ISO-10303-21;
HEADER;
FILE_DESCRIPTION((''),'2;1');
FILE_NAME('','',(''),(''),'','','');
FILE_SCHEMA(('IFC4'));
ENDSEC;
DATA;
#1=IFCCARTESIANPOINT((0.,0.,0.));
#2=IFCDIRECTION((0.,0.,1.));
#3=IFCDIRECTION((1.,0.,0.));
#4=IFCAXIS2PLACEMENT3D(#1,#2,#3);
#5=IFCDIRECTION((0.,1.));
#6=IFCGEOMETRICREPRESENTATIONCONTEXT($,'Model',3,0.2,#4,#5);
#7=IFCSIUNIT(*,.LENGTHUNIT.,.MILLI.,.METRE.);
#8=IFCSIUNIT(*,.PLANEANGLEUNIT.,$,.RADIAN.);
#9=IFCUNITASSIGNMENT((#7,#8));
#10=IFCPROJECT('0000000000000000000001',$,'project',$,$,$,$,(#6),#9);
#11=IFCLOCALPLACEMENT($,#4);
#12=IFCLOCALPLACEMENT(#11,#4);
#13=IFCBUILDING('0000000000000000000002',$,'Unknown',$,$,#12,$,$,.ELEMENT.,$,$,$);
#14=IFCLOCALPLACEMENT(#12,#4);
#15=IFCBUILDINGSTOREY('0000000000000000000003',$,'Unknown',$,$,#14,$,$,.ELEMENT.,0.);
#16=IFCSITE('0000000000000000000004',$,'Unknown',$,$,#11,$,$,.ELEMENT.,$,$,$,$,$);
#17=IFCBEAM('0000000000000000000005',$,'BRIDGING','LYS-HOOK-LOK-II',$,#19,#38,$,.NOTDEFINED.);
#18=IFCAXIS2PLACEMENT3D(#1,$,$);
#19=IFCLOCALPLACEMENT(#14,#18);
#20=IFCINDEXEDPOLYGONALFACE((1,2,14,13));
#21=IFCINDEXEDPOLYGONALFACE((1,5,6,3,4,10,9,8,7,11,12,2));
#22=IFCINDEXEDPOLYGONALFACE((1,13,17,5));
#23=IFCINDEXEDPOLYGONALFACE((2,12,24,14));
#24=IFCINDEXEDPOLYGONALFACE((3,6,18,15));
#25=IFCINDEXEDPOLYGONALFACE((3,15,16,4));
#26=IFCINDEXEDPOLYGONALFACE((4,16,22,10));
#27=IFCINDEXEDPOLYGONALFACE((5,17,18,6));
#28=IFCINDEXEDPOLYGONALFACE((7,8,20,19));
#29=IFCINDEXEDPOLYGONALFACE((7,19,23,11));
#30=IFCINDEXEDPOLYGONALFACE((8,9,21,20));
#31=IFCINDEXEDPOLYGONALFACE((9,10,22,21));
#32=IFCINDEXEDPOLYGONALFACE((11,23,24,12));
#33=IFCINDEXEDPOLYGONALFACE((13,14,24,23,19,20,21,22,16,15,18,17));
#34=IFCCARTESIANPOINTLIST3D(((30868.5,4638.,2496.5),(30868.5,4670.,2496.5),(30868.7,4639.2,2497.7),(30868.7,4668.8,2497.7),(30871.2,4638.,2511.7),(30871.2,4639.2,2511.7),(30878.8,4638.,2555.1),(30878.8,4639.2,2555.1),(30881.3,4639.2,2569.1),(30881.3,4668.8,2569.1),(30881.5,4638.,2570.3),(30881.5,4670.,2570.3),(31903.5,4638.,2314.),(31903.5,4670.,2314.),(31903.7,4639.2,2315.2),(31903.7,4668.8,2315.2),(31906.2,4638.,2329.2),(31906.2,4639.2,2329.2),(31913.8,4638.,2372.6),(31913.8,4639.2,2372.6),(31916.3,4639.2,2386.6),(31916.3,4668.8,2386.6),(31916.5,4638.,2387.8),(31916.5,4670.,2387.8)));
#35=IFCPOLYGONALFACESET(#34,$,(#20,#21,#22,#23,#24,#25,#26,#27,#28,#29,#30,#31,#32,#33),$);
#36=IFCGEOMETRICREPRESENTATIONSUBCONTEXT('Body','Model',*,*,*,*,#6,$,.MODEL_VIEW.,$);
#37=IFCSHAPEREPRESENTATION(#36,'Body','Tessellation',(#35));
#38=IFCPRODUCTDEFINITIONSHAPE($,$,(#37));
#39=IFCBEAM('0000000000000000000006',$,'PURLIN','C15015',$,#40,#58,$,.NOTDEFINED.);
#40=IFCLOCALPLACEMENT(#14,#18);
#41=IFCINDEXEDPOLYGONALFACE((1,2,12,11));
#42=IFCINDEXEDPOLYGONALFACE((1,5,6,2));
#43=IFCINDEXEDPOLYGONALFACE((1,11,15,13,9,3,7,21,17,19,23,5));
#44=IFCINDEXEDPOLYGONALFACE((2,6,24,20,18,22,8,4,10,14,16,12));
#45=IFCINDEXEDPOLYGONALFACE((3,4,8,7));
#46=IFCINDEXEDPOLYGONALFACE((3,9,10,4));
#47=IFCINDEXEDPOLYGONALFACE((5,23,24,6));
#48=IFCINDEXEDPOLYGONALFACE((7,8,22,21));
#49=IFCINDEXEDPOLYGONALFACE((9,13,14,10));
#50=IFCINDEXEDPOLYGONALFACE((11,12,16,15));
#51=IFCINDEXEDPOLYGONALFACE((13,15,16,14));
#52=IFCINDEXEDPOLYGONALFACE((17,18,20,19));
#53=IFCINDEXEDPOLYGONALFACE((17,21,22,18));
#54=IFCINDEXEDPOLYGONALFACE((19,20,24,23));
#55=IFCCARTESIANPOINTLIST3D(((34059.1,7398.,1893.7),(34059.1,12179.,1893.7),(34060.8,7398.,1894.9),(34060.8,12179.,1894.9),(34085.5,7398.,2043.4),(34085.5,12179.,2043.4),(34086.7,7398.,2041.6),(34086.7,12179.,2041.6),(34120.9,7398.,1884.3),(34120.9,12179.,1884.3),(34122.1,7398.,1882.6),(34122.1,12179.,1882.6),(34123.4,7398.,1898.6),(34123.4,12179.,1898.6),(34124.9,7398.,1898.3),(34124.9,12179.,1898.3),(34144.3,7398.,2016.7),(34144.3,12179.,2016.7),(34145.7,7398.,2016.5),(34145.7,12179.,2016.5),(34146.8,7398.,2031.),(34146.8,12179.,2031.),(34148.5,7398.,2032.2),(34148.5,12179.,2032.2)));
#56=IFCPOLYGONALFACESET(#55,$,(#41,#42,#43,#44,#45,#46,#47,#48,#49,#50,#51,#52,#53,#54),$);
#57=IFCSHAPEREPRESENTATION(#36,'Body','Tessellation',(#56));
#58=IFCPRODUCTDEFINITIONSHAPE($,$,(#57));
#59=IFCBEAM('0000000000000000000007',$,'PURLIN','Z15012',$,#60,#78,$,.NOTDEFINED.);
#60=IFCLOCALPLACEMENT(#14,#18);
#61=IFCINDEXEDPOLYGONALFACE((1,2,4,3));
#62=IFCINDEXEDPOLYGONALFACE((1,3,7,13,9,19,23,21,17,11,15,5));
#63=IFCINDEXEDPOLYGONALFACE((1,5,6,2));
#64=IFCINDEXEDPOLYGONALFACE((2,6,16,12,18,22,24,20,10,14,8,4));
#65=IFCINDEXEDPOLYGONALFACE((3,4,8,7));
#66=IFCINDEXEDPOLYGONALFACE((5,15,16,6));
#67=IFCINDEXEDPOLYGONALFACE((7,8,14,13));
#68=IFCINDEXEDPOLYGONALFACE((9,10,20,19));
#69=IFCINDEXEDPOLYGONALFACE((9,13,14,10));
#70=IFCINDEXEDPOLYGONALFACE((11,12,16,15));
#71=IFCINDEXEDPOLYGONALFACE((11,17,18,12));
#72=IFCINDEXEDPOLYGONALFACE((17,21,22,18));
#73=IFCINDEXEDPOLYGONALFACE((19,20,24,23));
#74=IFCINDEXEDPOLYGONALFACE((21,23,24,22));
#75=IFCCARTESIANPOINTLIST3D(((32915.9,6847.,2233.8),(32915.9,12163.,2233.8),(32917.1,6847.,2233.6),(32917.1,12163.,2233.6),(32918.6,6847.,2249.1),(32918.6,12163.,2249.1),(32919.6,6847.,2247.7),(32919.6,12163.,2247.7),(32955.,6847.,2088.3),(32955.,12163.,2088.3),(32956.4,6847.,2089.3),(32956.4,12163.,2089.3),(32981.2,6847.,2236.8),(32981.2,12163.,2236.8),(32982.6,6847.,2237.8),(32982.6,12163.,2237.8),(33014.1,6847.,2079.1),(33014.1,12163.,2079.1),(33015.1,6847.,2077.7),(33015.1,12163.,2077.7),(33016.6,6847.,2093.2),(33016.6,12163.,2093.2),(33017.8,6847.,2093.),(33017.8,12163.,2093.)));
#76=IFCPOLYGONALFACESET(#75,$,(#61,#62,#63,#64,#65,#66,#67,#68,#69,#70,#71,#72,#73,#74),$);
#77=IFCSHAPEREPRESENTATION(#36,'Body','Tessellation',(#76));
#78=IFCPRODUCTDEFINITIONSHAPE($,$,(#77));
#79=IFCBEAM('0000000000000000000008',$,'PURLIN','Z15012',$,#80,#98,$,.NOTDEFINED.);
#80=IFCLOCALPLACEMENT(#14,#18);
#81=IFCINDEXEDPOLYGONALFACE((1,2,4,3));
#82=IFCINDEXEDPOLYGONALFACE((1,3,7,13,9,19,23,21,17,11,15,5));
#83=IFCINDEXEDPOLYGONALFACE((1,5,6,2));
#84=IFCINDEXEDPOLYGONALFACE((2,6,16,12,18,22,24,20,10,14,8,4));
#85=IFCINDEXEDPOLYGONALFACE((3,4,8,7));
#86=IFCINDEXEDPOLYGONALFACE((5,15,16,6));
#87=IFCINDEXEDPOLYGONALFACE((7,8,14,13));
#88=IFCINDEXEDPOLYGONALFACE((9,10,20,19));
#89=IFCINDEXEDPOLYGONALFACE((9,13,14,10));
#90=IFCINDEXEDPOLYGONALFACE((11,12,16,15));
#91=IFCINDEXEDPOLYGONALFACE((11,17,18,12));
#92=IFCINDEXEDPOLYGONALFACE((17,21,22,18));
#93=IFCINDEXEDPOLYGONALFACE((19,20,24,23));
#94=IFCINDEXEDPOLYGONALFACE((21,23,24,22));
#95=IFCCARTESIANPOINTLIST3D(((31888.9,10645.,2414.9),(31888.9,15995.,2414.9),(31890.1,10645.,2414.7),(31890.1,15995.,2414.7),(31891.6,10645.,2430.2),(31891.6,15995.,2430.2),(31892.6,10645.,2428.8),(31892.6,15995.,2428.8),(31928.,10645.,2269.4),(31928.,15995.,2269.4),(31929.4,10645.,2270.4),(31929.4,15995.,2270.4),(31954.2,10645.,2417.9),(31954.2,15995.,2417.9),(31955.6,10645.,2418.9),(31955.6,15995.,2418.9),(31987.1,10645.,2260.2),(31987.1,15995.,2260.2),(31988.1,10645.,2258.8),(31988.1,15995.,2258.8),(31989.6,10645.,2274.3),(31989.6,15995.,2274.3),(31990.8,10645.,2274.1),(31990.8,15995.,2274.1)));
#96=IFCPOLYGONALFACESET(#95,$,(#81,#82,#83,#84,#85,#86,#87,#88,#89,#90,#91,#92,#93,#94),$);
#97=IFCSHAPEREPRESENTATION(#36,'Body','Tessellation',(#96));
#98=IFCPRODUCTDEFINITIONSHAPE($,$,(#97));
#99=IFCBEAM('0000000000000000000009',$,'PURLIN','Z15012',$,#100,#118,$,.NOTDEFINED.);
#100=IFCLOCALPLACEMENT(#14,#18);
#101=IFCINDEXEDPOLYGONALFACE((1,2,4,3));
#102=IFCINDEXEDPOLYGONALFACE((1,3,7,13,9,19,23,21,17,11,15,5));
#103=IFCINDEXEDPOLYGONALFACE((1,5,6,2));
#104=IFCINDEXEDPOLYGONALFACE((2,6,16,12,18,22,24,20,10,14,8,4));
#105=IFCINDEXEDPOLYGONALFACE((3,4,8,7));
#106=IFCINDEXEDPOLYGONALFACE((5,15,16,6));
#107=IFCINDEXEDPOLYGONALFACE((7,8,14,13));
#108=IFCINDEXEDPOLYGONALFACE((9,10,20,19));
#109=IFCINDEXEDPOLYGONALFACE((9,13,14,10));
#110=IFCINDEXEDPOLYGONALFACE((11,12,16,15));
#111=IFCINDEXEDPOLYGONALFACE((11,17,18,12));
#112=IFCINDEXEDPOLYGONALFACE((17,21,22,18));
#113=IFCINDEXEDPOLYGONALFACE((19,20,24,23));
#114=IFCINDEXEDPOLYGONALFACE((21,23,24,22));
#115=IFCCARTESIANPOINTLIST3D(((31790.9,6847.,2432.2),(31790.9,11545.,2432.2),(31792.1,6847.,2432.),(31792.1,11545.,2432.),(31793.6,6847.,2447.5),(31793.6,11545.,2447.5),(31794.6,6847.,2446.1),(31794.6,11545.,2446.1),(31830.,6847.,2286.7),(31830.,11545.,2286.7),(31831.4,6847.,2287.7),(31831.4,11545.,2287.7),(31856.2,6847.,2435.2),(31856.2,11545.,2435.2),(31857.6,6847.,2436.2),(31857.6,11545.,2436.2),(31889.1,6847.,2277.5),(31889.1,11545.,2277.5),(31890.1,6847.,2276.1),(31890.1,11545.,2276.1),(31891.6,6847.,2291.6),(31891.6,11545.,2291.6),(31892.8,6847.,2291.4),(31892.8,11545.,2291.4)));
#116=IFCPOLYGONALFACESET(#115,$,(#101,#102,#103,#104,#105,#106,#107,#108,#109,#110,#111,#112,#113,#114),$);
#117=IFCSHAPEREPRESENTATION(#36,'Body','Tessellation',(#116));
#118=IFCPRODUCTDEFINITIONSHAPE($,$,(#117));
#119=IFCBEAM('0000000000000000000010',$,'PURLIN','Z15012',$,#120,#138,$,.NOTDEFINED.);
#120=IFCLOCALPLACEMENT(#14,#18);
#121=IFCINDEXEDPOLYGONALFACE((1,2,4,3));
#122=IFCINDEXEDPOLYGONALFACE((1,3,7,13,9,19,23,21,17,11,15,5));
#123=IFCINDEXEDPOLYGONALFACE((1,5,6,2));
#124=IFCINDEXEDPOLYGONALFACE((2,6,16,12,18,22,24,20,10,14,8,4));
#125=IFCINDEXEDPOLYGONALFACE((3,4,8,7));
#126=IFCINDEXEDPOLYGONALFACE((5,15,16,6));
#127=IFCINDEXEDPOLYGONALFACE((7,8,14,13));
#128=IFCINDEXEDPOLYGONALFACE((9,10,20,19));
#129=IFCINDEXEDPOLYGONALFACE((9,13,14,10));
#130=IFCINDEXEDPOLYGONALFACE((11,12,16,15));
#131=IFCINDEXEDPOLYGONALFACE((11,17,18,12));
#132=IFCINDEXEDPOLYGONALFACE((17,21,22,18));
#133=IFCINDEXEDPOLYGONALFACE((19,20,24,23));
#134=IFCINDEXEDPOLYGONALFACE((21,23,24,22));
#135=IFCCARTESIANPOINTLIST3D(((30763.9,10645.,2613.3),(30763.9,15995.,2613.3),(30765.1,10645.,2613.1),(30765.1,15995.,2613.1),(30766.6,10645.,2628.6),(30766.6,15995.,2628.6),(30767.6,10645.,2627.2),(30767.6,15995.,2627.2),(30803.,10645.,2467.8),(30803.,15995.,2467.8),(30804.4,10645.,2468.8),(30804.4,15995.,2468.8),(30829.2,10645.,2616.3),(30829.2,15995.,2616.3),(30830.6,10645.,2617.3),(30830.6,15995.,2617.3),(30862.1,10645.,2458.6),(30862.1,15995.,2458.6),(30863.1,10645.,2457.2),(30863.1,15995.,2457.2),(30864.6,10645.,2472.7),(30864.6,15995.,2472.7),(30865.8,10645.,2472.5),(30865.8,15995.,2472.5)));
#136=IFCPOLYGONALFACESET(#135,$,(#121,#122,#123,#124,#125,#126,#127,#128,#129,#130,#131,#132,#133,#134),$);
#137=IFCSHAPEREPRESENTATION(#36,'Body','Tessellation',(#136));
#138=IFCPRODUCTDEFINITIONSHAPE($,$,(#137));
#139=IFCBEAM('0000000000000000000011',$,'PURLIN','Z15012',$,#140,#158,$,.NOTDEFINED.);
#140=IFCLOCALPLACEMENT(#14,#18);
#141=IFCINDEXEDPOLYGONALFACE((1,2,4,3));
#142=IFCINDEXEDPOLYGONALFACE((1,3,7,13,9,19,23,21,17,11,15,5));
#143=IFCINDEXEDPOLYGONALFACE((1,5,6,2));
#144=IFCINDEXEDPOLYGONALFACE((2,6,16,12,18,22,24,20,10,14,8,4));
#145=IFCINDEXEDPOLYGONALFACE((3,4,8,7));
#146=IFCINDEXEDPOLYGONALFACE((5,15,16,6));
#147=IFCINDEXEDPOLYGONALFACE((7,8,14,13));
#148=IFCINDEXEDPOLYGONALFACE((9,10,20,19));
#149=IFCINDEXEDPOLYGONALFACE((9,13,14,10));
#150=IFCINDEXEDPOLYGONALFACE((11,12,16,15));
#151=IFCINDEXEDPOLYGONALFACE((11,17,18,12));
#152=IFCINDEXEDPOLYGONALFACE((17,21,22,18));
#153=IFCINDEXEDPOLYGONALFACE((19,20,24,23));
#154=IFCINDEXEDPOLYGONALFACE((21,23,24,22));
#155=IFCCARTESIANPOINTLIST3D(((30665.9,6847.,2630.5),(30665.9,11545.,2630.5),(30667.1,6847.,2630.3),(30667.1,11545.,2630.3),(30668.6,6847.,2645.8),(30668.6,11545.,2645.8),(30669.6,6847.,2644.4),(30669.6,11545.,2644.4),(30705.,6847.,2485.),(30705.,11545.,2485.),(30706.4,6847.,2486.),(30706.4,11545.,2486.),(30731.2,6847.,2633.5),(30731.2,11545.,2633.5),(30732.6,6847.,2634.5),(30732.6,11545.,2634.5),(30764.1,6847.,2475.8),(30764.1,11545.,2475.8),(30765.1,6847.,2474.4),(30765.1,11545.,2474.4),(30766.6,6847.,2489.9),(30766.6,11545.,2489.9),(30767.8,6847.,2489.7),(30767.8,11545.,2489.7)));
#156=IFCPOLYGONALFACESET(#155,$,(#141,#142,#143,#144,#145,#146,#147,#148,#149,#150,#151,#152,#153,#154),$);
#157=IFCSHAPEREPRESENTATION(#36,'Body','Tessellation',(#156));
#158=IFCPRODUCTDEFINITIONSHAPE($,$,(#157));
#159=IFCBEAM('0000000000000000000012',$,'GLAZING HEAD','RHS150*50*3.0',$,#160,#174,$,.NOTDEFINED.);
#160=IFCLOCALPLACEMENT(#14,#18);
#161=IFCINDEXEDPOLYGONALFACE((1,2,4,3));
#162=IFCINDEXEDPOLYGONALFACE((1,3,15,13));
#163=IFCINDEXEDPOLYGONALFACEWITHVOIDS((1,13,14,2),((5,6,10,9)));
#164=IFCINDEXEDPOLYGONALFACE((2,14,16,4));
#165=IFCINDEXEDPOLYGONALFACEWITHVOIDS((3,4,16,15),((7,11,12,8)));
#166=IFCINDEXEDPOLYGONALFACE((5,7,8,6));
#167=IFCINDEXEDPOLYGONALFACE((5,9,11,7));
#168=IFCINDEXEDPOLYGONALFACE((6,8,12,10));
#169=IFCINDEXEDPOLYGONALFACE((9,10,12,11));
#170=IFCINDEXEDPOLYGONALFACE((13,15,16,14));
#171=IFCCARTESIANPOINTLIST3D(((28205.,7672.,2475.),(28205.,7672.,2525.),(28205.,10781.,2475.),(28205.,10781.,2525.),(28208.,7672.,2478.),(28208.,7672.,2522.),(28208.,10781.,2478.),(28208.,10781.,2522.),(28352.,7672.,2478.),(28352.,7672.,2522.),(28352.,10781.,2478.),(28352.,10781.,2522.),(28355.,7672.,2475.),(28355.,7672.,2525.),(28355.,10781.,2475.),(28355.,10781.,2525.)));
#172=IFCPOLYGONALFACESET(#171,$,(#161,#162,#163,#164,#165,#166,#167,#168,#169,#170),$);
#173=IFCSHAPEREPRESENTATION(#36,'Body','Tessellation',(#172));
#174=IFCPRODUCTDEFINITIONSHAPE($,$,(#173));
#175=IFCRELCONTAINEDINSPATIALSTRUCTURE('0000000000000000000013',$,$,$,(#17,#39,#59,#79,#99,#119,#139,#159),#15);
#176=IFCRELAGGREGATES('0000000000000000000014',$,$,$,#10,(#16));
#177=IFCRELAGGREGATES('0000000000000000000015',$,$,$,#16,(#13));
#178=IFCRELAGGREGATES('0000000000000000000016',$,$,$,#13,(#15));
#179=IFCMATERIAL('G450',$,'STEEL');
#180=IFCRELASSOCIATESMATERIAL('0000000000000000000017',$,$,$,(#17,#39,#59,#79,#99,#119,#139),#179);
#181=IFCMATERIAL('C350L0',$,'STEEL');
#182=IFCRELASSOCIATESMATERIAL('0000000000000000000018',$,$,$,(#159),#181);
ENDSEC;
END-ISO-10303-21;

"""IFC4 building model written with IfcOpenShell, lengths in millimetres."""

from ifc_helpers import new_model, si_unit, direction, frame, origin_with_axes, place, context, subcontext, project, spatial, line, indexed_curve, outline, extrude, material, element, save


model = new_model("IFC4")

# Units and contexts
model_context = context("Model", 3, precision=0.2, world=origin_with_axes(), true_north=direction((0.0, 1.0)))
body_context = subcontext(model_context, "Body", "Model", "MODEL_VIEW")
ifc_project = project(units=[si_unit("LENGTHUNIT", "METRE", prefix="MILLI"), si_unit("PLANEANGLEUNIT", "RADIAN")], contexts=[model_context])

# Site, building, storey
site_placement = place(None, origin_with_axes())
site = spatial("IfcSite", under=ifc_project, at=site_placement, Name="Unknown", CompositionType="ELEMENT")
building_placement = place(site_placement, origin_with_axes())
building = spatial("IfcBuilding", under=site, at=building_placement, Name="Unknown", CompositionType="ELEMENT")
storey_placement = place(building_placement, origin_with_axes())
storey = spatial("IfcBuildingStorey", under=building, at=storey_placement, Name="Unknown", CompositionType="ELEMENT", Elevation=0.0)

# Shared definitions
ifc_material_1 = material(Name="C350L0", Category="STEEL")

# Beams
ifc_material_2 = material(Name="G450", Category="STEEL")
beam_1_placement = place(storey_placement, frame((30875.0, 4654.0, 2533.4), z_axis=(0.0, -1.0, 0.0), x_axis=(0.984807, 0.0, -0.17365)))
element("IfcBeam", 1, at=beam_1_placement, inside=storey, material=ifc_material_2, Name="BRIDGING", Description="LYS-HOOK-LOK-II", PredefinedType="NOTDEFINED", context=body_context, shape_type="SolidModel", body=[
    extrude(outline(indexed_curve([(16.0, -37.5), (16.0, -22.0), (14.8, -22.0), (14.8, -36.3), (-14.8, -36.3), (-14.8, 36.3), (14.8, 36.3), (14.8, 22.0), (16.0, 22.0), (16.0, 37.5), (-16.0, 37.5), (-16.0, -37.5)], segments=[line(1, 2, 3, 4, 5, 6, 7, 8, 9, 10, 11, 12, 1)])), frame((0.0, 0.0, 0.0), z_axis=(-1.0, 0.0, 0.0), x_axis=(0.0, 0.0, 1.0)), (0.0, 0.0, -1.0), 1051.0),
])
beam_2_placement = place(storey_placement, frame((34103.8, 7398.0, 1963.0), z_axis=(0.984808, 0.0, -0.173648), x_axis=(0.0, 1.0, 0.0)))
element("IfcBeam", 2, at=beam_2_placement, inside=storey, material=ifc_material_2, Name="PURLIN", Description="C15015", PredefinedType="NOTDEFINED", context=body_context, shape_type="SolidModel", body=[
    extrude(outline(indexed_curve([(32.0, -76.0), (32.0, -60.0), (30.5, -60.0), (30.5, -74.5), (-30.5, -74.5), (-30.5, 74.5), (30.5, 74.5), (30.5, 60.0), (32.0, 60.0), (32.0, 76.0), (-32.0, 76.0), (-32.0, -76.0)], segments=[line(1, 2, 3, 4, 5, 6, 7, 8, 9, 10, 11, 12, 1)])), frame((0.0, 0.0, 0.0), z_axis=(-1.0, 0.0, 0.0), x_axis=(0.0, 0.0, 1.0)), (0.0, 0.0, -1.0), 4781.0),
])
beam_3_placement = place(storey_placement, frame((32968.8, 6847.0, 2163.1), z_axis=(0.984808, 0.0, -0.173648), x_axis=(0.0, 1.0, 0.0)))
element("IfcBeam", 3, at=beam_3_placement, inside=storey, material=ifc_material_2, Name="PURLIN", Description="Z15012", PredefinedType="NOTDEFINED", context=body_context, shape_type="SolidModel", body=[
    extrude(outline(indexed_curve([(60.4, -76.0), (60.4, -60.5), (59.2, -60.5), (59.2, -74.8), (0.6, -74.8), (0.6, 76.0), (-64.4, 76.0), (-64.4, 60.5), (-63.2, 60.5), (-63.2, 74.8), (-0.6, 74.8), (-0.6, -76.0)], segments=[line(1, 2, 3, 4, 5, 6, 7, 8, 9, 10, 11, 12, 1)])), frame((0.0, 0.0, 0.0), z_axis=(-1.0, 0.0, 0.0), x_axis=(0.0, 0.0, 1.0)), (0.0, 0.0, -1.0), 5316.0),
])
beam_4_placement = place(storey_placement, frame((31941.8, 10645.0, 2344.2), z_axis=(0.984808, 0.0, -0.173648), x_axis=(0.0, 1.0, 0.0)))
element("IfcBeam", 4, at=beam_4_placement, inside=storey, material=ifc_material_2, Name="PURLIN", Description="Z15012", PredefinedType="NOTDEFINED", context=body_context, shape_type="SolidModel", body=[
    extrude(outline(indexed_curve([(60.4, -76.0), (60.4, -60.5), (59.2, -60.5), (59.2, -74.8), (0.6, -74.8), (0.6, 76.0), (-64.4, 76.0), (-64.4, 60.5), (-63.2, 60.5), (-63.2, 74.8), (-0.6, 74.8), (-0.6, -76.0)], segments=[line(1, 2, 3, 4, 5, 6, 7, 8, 9, 10, 11, 12, 1)])), frame((0.0, 0.0, 0.0), z_axis=(-1.0, 0.0, 0.0), x_axis=(0.0, 0.0, 1.0)), (0.0, 0.0, -1.0), 5350.0),
])
beam_5_placement = place(storey_placement, frame((31843.8, 6847.0, 2361.5), z_axis=(0.984808, 0.0, -0.173648), x_axis=(0.0, 1.0, 0.0)))
element("IfcBeam", 5, at=beam_5_placement, inside=storey, material=ifc_material_2, Name="PURLIN", Description="Z15012", PredefinedType="NOTDEFINED", context=body_context, shape_type="SolidModel", body=[
    extrude(outline(indexed_curve([(60.4, -76.0), (60.4, -60.5), (59.2, -60.5), (59.2, -74.8), (0.6, -74.8), (0.6, 76.0), (-64.4, 76.0), (-64.4, 60.5), (-63.2, 60.5), (-63.2, 74.8), (-0.6, 74.8), (-0.6, -76.0)], segments=[line(1, 2, 3, 4, 5, 6, 7, 8, 9, 10, 11, 12, 1)])), frame((0.0, 0.0, 0.0), z_axis=(-1.0, 0.0, 0.0), x_axis=(0.0, 0.0, 1.0)), (0.0, 0.0, -1.0), 4698.0),
])
beam_6_placement = place(storey_placement, frame((30816.8, 10645.0, 2542.6), z_axis=(0.984808, 0.0, -0.173648), x_axis=(0.0, 1.0, 0.0)))
element("IfcBeam", 6, at=beam_6_placement, inside=storey, material=ifc_material_2, Name="PURLIN", Description="Z15012", PredefinedType="NOTDEFINED", context=body_context, shape_type="SolidModel", body=[
    extrude(outline(indexed_curve([(60.4, -76.0), (60.4, -60.5), (59.2, -60.5), (59.2, -74.8), (0.6, -74.8), (0.6, 76.0), (-64.4, 76.0), (-64.4, 60.5), (-63.2, 60.5), (-63.2, 74.8), (-0.6, 74.8), (-0.6, -76.0)], segments=[line(1, 2, 3, 4, 5, 6, 7, 8, 9, 10, 11, 12, 1)])), frame((0.0, 0.0, 0.0), z_axis=(-1.0, 0.0, 0.0), x_axis=(0.0, 0.0, 1.0)), (0.0, 0.0, -1.0), 5350.0),
])
beam_7_placement = place(storey_placement, frame((30718.8, 6847.0, 2559.8), z_axis=(0.984808, 0.0, -0.173648), x_axis=(0.0, 1.0, 0.0)))
element("IfcBeam", 7, at=beam_7_placement, inside=storey, material=ifc_material_2, Name="PURLIN", Description="Z15012", PredefinedType="NOTDEFINED", context=body_context, shape_type="SolidModel", body=[
    extrude(outline(indexed_curve([(60.4, -76.0), (60.4, -60.5), (59.2, -60.5), (59.2, -74.8), (0.6, -74.8), (0.6, 76.0), (-64.4, 76.0), (-64.4, 60.5), (-63.2, 60.5), (-63.2, 74.8), (-0.6, 74.8), (-0.6, -76.0)], segments=[line(1, 2, 3, 4, 5, 6, 7, 8, 9, 10, 11, 12, 1)])), frame((0.0, 0.0, 0.0), z_axis=(-1.0, 0.0, 0.0), x_axis=(0.0, 0.0, 1.0)), (0.0, 0.0, -1.0), 4698.0),
])
beam_8_placement = place(storey_placement, frame((28280.0, 7672.0, 2500.0), z_axis=(0.0, 0.0, 1.0), x_axis=(0.0, 1.0, 0.0)))
element("IfcBeam", 8, at=beam_8_placement, inside=storey, material=ifc_material_1, Name="GLAZING HEAD", Description="RHS150*50*3.0", PredefinedType="NOTDEFINED", context=body_context, shape_type="SolidModel", body=[
    extrude(outline(indexed_curve([(-25.0, -75.0), (25.0, -75.0), (25.0, 75.0), (-25.0, 75.0)], segments=[line(1, 2, 3, 4, 1)]), holes=[indexed_curve([(-22.0, -72.0), (-22.0, 72.0), (22.0, 72.0), (22.0, -72.0)], segments=[line(1, 2, 3, 4, 1)])]), frame((0.0, 0.0, 0.0), z_axis=(-1.0, 0.0, 0.0), x_axis=(0.0, 0.0, 1.0)), (0.0, 0.0, -1.0), 3109.0),
])

save(model, "model.ifc")
